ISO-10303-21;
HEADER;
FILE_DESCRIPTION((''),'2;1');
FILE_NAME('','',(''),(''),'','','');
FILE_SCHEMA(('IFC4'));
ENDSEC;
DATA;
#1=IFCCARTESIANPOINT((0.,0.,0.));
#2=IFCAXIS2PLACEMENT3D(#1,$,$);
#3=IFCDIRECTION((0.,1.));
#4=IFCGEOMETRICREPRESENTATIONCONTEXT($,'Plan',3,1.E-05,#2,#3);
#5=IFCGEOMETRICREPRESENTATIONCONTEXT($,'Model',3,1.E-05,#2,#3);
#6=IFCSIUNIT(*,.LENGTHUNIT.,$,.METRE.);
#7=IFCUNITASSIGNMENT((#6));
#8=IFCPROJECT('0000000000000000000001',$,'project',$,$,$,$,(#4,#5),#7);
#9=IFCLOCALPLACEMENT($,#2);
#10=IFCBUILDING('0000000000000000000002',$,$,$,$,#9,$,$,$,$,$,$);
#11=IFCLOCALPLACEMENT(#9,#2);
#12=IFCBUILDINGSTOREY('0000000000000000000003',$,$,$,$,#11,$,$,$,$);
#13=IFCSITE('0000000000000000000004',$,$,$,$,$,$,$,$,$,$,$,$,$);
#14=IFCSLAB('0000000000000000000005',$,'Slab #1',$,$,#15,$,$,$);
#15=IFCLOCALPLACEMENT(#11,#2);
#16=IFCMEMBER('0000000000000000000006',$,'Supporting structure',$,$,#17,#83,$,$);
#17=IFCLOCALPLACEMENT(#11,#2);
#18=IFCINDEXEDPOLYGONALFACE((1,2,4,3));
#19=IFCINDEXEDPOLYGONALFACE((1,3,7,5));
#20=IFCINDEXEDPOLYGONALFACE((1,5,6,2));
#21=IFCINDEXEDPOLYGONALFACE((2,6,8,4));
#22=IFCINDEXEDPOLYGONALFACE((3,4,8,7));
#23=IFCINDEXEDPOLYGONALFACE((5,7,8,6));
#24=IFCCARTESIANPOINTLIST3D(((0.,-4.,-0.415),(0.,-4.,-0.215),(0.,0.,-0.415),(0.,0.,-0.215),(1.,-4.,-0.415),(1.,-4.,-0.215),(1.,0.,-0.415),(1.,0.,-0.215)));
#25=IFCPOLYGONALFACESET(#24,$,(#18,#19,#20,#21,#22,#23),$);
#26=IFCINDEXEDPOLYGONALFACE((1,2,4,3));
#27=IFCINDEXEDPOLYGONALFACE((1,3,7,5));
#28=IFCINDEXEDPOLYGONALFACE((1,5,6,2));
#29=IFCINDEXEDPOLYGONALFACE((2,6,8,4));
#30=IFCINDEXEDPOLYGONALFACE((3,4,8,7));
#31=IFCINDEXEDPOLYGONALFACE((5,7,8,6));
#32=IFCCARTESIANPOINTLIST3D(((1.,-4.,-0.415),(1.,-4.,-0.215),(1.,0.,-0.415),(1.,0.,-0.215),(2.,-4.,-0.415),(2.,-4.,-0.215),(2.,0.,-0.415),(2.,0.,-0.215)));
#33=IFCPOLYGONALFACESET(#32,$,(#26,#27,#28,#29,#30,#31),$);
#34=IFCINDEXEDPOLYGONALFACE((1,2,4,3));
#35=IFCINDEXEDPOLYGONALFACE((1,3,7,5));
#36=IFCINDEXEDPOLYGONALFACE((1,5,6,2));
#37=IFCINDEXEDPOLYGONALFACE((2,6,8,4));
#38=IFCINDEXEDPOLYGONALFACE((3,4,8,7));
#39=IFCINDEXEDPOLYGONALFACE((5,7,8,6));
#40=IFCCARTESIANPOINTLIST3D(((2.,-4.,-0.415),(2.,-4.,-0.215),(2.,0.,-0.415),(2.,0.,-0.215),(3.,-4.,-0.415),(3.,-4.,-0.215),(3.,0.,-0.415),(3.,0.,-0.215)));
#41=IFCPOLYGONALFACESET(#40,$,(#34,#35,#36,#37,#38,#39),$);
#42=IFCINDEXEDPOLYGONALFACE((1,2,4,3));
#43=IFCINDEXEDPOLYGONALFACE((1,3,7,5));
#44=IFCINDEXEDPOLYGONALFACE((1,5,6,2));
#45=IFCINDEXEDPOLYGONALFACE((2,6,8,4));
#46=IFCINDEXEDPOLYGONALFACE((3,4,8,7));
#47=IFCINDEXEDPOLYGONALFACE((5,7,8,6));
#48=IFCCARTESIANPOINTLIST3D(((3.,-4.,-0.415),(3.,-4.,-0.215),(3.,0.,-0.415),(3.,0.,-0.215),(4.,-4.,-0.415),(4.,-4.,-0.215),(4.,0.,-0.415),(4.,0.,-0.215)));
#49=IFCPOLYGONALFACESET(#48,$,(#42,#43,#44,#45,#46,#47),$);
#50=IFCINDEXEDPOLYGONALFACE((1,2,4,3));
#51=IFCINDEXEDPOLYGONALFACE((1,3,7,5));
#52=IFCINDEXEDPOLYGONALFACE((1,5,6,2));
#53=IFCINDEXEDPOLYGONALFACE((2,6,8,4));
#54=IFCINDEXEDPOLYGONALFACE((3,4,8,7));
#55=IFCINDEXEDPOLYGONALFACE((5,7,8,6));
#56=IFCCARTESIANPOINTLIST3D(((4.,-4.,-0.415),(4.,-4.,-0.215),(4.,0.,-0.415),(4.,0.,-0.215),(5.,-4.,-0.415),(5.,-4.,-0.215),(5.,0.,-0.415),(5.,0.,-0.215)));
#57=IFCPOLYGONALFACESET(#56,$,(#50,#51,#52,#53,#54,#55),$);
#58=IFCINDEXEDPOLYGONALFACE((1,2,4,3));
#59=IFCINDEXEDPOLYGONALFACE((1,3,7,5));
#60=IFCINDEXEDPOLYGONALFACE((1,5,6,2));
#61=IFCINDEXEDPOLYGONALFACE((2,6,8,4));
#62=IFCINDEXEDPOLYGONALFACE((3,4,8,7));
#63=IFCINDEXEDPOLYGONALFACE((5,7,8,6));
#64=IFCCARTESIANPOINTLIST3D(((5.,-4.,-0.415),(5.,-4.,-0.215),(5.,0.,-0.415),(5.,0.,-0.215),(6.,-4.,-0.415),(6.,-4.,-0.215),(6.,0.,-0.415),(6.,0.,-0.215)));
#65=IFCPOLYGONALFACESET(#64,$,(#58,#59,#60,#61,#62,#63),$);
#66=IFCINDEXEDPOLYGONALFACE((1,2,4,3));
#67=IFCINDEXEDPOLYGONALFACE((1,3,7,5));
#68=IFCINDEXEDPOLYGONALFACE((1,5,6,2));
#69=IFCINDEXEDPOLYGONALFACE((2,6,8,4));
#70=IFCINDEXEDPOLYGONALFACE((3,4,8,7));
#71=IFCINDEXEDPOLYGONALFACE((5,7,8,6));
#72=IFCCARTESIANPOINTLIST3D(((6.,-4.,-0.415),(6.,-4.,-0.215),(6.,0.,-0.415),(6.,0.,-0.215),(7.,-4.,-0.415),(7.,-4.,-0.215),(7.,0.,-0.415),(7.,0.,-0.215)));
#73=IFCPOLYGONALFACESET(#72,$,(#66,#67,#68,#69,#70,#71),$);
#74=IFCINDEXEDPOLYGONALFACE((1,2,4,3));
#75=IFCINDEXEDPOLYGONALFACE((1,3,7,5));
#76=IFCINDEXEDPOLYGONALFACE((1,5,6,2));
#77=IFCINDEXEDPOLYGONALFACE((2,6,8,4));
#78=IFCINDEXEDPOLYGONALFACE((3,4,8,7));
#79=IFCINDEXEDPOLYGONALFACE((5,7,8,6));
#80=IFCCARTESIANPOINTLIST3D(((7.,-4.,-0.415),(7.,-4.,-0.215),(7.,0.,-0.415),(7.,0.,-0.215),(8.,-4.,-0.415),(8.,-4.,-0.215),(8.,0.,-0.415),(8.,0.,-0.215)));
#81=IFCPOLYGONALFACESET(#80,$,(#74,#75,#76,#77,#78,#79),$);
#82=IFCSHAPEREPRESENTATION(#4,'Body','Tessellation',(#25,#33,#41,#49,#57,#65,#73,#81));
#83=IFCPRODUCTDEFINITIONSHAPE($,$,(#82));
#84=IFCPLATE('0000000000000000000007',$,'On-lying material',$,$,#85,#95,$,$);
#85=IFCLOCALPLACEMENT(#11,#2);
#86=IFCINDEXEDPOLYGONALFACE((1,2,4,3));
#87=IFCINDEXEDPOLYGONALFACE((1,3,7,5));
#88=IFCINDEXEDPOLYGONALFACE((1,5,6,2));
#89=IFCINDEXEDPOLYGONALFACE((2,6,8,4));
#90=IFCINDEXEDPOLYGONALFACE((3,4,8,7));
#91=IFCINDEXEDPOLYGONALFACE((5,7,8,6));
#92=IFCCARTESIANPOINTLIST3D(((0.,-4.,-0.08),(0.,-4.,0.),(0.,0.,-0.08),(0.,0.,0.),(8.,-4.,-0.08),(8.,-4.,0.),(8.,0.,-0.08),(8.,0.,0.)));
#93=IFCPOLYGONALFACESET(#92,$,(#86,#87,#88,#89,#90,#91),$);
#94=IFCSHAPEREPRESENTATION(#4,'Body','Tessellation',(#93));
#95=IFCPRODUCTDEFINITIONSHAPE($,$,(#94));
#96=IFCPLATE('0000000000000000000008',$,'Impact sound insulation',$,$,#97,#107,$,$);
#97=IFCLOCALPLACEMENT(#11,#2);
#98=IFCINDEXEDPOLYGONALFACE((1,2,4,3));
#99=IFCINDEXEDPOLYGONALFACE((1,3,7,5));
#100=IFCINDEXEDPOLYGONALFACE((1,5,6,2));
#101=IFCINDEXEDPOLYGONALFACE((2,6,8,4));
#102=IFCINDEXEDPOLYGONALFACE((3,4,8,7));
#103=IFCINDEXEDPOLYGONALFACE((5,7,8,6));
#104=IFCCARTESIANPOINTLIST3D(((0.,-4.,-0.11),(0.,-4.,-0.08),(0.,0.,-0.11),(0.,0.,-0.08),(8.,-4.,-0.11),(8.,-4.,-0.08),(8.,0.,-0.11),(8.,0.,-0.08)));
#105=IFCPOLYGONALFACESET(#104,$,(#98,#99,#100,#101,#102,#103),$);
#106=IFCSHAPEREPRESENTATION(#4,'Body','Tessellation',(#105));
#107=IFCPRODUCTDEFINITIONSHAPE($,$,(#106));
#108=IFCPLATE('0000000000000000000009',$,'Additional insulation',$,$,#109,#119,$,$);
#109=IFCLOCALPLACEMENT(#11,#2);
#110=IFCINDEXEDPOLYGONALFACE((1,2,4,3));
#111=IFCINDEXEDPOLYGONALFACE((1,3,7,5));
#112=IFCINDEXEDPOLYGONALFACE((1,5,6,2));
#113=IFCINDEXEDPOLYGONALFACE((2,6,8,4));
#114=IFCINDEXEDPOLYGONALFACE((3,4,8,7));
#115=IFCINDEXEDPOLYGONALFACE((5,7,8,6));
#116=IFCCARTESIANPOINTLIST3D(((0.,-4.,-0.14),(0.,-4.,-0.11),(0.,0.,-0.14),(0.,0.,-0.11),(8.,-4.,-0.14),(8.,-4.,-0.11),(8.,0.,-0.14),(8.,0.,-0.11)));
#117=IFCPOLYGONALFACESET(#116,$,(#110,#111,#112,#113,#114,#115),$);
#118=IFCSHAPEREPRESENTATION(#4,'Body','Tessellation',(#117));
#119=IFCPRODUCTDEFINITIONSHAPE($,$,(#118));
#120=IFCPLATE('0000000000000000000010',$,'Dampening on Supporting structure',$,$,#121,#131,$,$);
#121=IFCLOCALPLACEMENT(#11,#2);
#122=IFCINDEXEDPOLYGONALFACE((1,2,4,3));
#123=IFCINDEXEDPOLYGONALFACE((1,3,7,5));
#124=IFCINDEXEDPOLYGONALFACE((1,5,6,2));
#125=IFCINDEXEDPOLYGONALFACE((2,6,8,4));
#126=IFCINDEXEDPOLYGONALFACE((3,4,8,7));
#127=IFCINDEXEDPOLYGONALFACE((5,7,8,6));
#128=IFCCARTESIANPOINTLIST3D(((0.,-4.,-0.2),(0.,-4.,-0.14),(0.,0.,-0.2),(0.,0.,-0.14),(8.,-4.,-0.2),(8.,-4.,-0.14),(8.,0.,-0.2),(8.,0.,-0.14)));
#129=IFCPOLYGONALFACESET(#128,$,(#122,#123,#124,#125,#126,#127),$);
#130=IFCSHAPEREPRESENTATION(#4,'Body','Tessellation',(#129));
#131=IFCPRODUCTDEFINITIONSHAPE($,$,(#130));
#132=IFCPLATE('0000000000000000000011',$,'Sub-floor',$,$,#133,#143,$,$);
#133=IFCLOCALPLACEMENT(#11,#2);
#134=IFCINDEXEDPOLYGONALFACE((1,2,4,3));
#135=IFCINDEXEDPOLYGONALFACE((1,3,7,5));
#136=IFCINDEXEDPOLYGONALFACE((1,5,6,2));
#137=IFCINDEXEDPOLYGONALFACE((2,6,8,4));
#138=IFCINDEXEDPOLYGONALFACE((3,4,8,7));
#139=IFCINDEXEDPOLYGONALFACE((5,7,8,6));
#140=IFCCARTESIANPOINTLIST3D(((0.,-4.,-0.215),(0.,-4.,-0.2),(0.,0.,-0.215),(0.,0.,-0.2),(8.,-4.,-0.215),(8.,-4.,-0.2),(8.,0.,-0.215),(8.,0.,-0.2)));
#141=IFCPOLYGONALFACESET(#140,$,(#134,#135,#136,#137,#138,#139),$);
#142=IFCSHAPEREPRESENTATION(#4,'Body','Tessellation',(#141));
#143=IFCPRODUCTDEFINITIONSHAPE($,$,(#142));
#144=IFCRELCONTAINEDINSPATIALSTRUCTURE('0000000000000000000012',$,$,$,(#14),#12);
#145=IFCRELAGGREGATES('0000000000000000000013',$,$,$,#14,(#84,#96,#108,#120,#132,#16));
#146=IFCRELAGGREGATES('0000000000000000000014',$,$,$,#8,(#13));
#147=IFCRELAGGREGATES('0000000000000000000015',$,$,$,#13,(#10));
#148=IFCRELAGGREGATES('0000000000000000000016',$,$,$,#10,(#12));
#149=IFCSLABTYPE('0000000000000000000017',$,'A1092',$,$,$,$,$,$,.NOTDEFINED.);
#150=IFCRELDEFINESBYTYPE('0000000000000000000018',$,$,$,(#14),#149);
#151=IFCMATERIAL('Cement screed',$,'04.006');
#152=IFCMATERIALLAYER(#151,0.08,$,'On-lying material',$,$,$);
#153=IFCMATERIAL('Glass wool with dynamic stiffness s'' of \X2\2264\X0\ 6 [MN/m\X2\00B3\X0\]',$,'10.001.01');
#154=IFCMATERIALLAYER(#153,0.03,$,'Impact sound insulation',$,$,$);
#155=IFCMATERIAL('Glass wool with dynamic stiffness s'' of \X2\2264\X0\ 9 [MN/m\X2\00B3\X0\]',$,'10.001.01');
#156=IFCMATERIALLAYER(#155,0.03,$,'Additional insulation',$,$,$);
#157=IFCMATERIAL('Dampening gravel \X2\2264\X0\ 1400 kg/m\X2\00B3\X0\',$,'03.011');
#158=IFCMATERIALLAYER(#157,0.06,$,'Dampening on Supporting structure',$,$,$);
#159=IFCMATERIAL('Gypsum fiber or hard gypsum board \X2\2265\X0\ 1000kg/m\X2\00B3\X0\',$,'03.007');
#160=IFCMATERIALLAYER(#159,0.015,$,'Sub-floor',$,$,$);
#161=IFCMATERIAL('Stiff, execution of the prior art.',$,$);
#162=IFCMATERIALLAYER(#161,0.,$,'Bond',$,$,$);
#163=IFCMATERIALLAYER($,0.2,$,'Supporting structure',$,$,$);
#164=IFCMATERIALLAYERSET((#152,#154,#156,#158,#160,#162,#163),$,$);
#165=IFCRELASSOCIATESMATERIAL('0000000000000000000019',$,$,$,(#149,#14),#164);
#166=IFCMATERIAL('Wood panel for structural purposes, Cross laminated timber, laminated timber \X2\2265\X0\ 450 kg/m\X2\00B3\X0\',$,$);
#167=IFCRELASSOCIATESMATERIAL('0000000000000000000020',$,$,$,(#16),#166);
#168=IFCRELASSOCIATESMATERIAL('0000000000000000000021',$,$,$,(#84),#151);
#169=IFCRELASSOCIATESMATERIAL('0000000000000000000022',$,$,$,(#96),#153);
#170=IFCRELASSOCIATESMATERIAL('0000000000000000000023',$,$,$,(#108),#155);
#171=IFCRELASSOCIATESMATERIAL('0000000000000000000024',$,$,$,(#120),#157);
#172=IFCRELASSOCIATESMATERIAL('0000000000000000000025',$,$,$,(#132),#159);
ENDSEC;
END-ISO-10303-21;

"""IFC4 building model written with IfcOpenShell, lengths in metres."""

from ifc_helpers import new_model, si_unit, direction, frame, frame_2d, origin, origin_with_axes, place, context, project, spatial, rectangle, extrude, material, layer, layer_set, type_object, element, aggregate, save


model = new_model("IFC4")

# Units and contexts
plan_context = context("Plan", 3, precision=1e-05, world=origin(), true_north=direction((0.0, 1.0)))
model_context = context("Model", 3, precision=1e-05, world=origin(), true_north=direction((0.0, 1.0)))
ifc_project = project(units=[si_unit("LENGTHUNIT", "METRE")], contexts=[plan_context, model_context])

# Site, building, storey
site = spatial("IfcSite", under=ifc_project)
building_placement = place(None, origin())
building = spatial("IfcBuilding", under=site, at=building_placement)
storey_placement = place(building_placement, origin())
storey = spatial("IfcBuildingStorey", under=building, at=storey_placement)

# Slab, member, plates
ifc_material_1 = material(Name="Cement screed", Category="04.006")
ifc_layer_1 = layer(ifc_material_1, 0.08, Name="On-lying material")
ifc_material_2 = material(Name="Glass wool with dynamic stiffness s' of ≤ 6 [MN/m³]", Category="10.001.01")
ifc_layer_2 = layer(ifc_material_2, 0.03, Name="Impact sound insulation")
ifc_material_3 = material(Name="Glass wool with dynamic stiffness s' of ≤ 9 [MN/m³]", Category="10.001.01")
ifc_layer_3 = layer(ifc_material_3, 0.03, Name="Additional insulation")
ifc_material_4 = material(Name="Dampening gravel ≤ 1400 kg/m³", Category="03.011")
ifc_layer_4 = layer(ifc_material_4, 0.06, Name="Dampening on Supporting structure")
ifc_material_5 = material(Name="Gypsum fiber or hard gypsum board ≥ 1000kg/m³", Category="03.007")
ifc_layer_5 = layer(ifc_material_5, 0.015, Name="Sub-floor")
ifc_material_6 = material(Name="Stiff, execution of the prior art.")
ifc_layer_6 = layer(ifc_material_6, 0.0, Name="Bond")
ifc_layer_7 = layer(None, 0.2, Name="Supporting structure")
ifc_layer_set = layer_set([ifc_layer_1, ifc_layer_2, ifc_layer_3, ifc_layer_4, ifc_layer_5, ifc_layer_6, ifc_layer_7])
slab_type = type_object("IfcSlabType", Name="A1092", PredefinedType="NOTDEFINED", material=ifc_layer_set)
slab_placement = place(None, frame((0.0, 0.0, 0.0), z_axis=(0.0, 0.0, -1.0), x_axis=(1.0, 0.0, 0.0)))
slab = element("IfcSlab", 1, at=slab_placement, inside=storey, type_object=slab_type, material=ifc_layer_set, Name="Slab #1")
ifc_material_7 = material(Name="Wood panel for structural purposes, Cross laminated timber, laminated timber ≥ 450 kg/m³")
member_placement = place(slab_placement, origin())
member = element("IfcMember", 2, at=member_placement, material=ifc_material_7, Name="Supporting structure", context=plan_context, shape_type="SweptSolid", body=[
    extrude(rectangle(XDim=1.0, YDim=0.2, at=frame_2d((0.5, 0.1), x_axis=(1.0, 0.0))), frame((0.0, 4.0, 0.215), z_axis=(0.0, -1.0, 0.0), x_axis=(1.0, 0.0, 0.0)), (0.0, 0.0, 1.0), 4.0),
    extrude(rectangle(XDim=1.0, YDim=0.2, at=frame_2d((0.5, 0.1), x_axis=(1.0, 0.0))), frame((1.0, 4.0, 0.215), z_axis=(0.0, -1.0, 0.0), x_axis=(1.0, 0.0, 0.0)), (0.0, 0.0, 1.0), 4.0),
    extrude(rectangle(XDim=1.0, YDim=0.2, at=frame_2d((0.5, 0.1), x_axis=(1.0, 0.0))), frame((2.0, 4.0, 0.215), z_axis=(0.0, -1.0, 0.0), x_axis=(1.0, 0.0, 0.0)), (0.0, 0.0, 1.0), 4.0),
    extrude(rectangle(XDim=1.0, YDim=0.2, at=frame_2d((0.5, 0.1), x_axis=(1.0, 0.0))), frame((3.0, 4.0, 0.215), z_axis=(0.0, -1.0, 0.0), x_axis=(1.0, 0.0, 0.0)), (0.0, 0.0, 1.0), 4.0),
    extrude(rectangle(XDim=1.0, YDim=0.2, at=frame_2d((0.5, 0.1), x_axis=(1.0, 0.0))), frame((4.0, 4.0, 0.215), z_axis=(0.0, -1.0, 0.0), x_axis=(1.0, 0.0, 0.0)), (0.0, 0.0, 1.0), 4.0),
    extrude(rectangle(XDim=1.0, YDim=0.2, at=frame_2d((0.5, 0.1), x_axis=(1.0, 0.0))), frame((5.0, 4.0, 0.215), z_axis=(0.0, -1.0, 0.0), x_axis=(1.0, 0.0, 0.0)), (0.0, 0.0, 1.0), 4.0),
    extrude(rectangle(XDim=1.0, YDim=0.2, at=frame_2d((0.5, 0.1), x_axis=(1.0, 0.0))), frame((6.0, 4.0, 0.215), z_axis=(0.0, -1.0, 0.0), x_axis=(1.0, 0.0, 0.0)), (0.0, 0.0, 1.0), 4.0),
    extrude(rectangle(XDim=1.0, YDim=0.2, at=frame_2d((0.5, 0.1), x_axis=(1.0, 0.0))), frame((7.0, 4.0, 0.215), z_axis=(0.0, -1.0, 0.0), x_axis=(1.0, 0.0, 0.0)), (0.0, 0.0, 1.0), 4.0),
])
plate_1_placement = place(slab_placement, origin())
plate_1 = element("IfcPlate", 3, at=plate_1_placement, material=ifc_material_1, Name="On-lying material", context=plan_context, shape_type="SweptSolid", body=[
    extrude(rectangle(XDim=8.0, YDim=4.0, at=frame_2d((4.0, 2.0), x_axis=(1.0, 0.0))), origin_with_axes(), (0.0, 0.0, 1.0), 0.08),
])
plate_2_placement = place(slab_placement, origin())
plate_2 = element("IfcPlate", 4, at=plate_2_placement, material=ifc_material_2, Name="Impact sound insulation", context=plan_context, shape_type="SweptSolid", body=[
    extrude(rectangle(XDim=8.0, YDim=4.0, at=frame_2d((4.0, 2.0), x_axis=(1.0, 0.0))), frame((0.0, 0.0, 0.08), z_axis=(0.0, 0.0, 1.0), x_axis=(1.0, 0.0, 0.0)), (0.0, 0.0, 1.0), 0.03),
])
plate_3_placement = place(slab_placement, origin())
plate_3 = element("IfcPlate", 5, at=plate_3_placement, material=ifc_material_3, Name="Additional insulation", context=plan_context, shape_type="SweptSolid", body=[
    extrude(rectangle(XDim=8.0, YDim=4.0, at=frame_2d((4.0, 2.0), x_axis=(1.0, 0.0))), frame((0.0, 0.0, 0.11), z_axis=(0.0, 0.0, 1.0), x_axis=(1.0, 0.0, 0.0)), (0.0, 0.0, 1.0), 0.03),
])
plate_4_placement = place(slab_placement, origin())
plate_4 = element("IfcPlate", 6, at=plate_4_placement, material=ifc_material_4, Name="Dampening on Supporting structure", context=plan_context, shape_type="SweptSolid", body=[
    extrude(rectangle(XDim=8.0, YDim=4.0, at=frame_2d((4.0, 2.0), x_axis=(1.0, 0.0))), frame((0.0, 0.0, 0.14), z_axis=(0.0, 0.0, 1.0), x_axis=(1.0, 0.0, 0.0)), (0.0, 0.0, 1.0), 0.06),
])
plate_5_placement = place(slab_placement, origin())
plate_5 = element("IfcPlate", 7, at=plate_5_placement, material=ifc_material_5, Name="Sub-floor", context=plan_context, shape_type="SweptSolid", body=[
    extrude(rectangle(XDim=8.0, YDim=4.0, at=frame_2d((4.0, 2.0), x_axis=(1.0, 0.0))), frame((0.0, 0.0, 0.2), z_axis=(0.0, 0.0, 1.0), x_axis=(1.0, 0.0, 0.0)), (0.0, 0.0, 1.0), 0.015),
])
aggregate(slab, [plate_1, plate_2, plate_3, plate_4, plate_5, member])

save(model, "model.ifc")
